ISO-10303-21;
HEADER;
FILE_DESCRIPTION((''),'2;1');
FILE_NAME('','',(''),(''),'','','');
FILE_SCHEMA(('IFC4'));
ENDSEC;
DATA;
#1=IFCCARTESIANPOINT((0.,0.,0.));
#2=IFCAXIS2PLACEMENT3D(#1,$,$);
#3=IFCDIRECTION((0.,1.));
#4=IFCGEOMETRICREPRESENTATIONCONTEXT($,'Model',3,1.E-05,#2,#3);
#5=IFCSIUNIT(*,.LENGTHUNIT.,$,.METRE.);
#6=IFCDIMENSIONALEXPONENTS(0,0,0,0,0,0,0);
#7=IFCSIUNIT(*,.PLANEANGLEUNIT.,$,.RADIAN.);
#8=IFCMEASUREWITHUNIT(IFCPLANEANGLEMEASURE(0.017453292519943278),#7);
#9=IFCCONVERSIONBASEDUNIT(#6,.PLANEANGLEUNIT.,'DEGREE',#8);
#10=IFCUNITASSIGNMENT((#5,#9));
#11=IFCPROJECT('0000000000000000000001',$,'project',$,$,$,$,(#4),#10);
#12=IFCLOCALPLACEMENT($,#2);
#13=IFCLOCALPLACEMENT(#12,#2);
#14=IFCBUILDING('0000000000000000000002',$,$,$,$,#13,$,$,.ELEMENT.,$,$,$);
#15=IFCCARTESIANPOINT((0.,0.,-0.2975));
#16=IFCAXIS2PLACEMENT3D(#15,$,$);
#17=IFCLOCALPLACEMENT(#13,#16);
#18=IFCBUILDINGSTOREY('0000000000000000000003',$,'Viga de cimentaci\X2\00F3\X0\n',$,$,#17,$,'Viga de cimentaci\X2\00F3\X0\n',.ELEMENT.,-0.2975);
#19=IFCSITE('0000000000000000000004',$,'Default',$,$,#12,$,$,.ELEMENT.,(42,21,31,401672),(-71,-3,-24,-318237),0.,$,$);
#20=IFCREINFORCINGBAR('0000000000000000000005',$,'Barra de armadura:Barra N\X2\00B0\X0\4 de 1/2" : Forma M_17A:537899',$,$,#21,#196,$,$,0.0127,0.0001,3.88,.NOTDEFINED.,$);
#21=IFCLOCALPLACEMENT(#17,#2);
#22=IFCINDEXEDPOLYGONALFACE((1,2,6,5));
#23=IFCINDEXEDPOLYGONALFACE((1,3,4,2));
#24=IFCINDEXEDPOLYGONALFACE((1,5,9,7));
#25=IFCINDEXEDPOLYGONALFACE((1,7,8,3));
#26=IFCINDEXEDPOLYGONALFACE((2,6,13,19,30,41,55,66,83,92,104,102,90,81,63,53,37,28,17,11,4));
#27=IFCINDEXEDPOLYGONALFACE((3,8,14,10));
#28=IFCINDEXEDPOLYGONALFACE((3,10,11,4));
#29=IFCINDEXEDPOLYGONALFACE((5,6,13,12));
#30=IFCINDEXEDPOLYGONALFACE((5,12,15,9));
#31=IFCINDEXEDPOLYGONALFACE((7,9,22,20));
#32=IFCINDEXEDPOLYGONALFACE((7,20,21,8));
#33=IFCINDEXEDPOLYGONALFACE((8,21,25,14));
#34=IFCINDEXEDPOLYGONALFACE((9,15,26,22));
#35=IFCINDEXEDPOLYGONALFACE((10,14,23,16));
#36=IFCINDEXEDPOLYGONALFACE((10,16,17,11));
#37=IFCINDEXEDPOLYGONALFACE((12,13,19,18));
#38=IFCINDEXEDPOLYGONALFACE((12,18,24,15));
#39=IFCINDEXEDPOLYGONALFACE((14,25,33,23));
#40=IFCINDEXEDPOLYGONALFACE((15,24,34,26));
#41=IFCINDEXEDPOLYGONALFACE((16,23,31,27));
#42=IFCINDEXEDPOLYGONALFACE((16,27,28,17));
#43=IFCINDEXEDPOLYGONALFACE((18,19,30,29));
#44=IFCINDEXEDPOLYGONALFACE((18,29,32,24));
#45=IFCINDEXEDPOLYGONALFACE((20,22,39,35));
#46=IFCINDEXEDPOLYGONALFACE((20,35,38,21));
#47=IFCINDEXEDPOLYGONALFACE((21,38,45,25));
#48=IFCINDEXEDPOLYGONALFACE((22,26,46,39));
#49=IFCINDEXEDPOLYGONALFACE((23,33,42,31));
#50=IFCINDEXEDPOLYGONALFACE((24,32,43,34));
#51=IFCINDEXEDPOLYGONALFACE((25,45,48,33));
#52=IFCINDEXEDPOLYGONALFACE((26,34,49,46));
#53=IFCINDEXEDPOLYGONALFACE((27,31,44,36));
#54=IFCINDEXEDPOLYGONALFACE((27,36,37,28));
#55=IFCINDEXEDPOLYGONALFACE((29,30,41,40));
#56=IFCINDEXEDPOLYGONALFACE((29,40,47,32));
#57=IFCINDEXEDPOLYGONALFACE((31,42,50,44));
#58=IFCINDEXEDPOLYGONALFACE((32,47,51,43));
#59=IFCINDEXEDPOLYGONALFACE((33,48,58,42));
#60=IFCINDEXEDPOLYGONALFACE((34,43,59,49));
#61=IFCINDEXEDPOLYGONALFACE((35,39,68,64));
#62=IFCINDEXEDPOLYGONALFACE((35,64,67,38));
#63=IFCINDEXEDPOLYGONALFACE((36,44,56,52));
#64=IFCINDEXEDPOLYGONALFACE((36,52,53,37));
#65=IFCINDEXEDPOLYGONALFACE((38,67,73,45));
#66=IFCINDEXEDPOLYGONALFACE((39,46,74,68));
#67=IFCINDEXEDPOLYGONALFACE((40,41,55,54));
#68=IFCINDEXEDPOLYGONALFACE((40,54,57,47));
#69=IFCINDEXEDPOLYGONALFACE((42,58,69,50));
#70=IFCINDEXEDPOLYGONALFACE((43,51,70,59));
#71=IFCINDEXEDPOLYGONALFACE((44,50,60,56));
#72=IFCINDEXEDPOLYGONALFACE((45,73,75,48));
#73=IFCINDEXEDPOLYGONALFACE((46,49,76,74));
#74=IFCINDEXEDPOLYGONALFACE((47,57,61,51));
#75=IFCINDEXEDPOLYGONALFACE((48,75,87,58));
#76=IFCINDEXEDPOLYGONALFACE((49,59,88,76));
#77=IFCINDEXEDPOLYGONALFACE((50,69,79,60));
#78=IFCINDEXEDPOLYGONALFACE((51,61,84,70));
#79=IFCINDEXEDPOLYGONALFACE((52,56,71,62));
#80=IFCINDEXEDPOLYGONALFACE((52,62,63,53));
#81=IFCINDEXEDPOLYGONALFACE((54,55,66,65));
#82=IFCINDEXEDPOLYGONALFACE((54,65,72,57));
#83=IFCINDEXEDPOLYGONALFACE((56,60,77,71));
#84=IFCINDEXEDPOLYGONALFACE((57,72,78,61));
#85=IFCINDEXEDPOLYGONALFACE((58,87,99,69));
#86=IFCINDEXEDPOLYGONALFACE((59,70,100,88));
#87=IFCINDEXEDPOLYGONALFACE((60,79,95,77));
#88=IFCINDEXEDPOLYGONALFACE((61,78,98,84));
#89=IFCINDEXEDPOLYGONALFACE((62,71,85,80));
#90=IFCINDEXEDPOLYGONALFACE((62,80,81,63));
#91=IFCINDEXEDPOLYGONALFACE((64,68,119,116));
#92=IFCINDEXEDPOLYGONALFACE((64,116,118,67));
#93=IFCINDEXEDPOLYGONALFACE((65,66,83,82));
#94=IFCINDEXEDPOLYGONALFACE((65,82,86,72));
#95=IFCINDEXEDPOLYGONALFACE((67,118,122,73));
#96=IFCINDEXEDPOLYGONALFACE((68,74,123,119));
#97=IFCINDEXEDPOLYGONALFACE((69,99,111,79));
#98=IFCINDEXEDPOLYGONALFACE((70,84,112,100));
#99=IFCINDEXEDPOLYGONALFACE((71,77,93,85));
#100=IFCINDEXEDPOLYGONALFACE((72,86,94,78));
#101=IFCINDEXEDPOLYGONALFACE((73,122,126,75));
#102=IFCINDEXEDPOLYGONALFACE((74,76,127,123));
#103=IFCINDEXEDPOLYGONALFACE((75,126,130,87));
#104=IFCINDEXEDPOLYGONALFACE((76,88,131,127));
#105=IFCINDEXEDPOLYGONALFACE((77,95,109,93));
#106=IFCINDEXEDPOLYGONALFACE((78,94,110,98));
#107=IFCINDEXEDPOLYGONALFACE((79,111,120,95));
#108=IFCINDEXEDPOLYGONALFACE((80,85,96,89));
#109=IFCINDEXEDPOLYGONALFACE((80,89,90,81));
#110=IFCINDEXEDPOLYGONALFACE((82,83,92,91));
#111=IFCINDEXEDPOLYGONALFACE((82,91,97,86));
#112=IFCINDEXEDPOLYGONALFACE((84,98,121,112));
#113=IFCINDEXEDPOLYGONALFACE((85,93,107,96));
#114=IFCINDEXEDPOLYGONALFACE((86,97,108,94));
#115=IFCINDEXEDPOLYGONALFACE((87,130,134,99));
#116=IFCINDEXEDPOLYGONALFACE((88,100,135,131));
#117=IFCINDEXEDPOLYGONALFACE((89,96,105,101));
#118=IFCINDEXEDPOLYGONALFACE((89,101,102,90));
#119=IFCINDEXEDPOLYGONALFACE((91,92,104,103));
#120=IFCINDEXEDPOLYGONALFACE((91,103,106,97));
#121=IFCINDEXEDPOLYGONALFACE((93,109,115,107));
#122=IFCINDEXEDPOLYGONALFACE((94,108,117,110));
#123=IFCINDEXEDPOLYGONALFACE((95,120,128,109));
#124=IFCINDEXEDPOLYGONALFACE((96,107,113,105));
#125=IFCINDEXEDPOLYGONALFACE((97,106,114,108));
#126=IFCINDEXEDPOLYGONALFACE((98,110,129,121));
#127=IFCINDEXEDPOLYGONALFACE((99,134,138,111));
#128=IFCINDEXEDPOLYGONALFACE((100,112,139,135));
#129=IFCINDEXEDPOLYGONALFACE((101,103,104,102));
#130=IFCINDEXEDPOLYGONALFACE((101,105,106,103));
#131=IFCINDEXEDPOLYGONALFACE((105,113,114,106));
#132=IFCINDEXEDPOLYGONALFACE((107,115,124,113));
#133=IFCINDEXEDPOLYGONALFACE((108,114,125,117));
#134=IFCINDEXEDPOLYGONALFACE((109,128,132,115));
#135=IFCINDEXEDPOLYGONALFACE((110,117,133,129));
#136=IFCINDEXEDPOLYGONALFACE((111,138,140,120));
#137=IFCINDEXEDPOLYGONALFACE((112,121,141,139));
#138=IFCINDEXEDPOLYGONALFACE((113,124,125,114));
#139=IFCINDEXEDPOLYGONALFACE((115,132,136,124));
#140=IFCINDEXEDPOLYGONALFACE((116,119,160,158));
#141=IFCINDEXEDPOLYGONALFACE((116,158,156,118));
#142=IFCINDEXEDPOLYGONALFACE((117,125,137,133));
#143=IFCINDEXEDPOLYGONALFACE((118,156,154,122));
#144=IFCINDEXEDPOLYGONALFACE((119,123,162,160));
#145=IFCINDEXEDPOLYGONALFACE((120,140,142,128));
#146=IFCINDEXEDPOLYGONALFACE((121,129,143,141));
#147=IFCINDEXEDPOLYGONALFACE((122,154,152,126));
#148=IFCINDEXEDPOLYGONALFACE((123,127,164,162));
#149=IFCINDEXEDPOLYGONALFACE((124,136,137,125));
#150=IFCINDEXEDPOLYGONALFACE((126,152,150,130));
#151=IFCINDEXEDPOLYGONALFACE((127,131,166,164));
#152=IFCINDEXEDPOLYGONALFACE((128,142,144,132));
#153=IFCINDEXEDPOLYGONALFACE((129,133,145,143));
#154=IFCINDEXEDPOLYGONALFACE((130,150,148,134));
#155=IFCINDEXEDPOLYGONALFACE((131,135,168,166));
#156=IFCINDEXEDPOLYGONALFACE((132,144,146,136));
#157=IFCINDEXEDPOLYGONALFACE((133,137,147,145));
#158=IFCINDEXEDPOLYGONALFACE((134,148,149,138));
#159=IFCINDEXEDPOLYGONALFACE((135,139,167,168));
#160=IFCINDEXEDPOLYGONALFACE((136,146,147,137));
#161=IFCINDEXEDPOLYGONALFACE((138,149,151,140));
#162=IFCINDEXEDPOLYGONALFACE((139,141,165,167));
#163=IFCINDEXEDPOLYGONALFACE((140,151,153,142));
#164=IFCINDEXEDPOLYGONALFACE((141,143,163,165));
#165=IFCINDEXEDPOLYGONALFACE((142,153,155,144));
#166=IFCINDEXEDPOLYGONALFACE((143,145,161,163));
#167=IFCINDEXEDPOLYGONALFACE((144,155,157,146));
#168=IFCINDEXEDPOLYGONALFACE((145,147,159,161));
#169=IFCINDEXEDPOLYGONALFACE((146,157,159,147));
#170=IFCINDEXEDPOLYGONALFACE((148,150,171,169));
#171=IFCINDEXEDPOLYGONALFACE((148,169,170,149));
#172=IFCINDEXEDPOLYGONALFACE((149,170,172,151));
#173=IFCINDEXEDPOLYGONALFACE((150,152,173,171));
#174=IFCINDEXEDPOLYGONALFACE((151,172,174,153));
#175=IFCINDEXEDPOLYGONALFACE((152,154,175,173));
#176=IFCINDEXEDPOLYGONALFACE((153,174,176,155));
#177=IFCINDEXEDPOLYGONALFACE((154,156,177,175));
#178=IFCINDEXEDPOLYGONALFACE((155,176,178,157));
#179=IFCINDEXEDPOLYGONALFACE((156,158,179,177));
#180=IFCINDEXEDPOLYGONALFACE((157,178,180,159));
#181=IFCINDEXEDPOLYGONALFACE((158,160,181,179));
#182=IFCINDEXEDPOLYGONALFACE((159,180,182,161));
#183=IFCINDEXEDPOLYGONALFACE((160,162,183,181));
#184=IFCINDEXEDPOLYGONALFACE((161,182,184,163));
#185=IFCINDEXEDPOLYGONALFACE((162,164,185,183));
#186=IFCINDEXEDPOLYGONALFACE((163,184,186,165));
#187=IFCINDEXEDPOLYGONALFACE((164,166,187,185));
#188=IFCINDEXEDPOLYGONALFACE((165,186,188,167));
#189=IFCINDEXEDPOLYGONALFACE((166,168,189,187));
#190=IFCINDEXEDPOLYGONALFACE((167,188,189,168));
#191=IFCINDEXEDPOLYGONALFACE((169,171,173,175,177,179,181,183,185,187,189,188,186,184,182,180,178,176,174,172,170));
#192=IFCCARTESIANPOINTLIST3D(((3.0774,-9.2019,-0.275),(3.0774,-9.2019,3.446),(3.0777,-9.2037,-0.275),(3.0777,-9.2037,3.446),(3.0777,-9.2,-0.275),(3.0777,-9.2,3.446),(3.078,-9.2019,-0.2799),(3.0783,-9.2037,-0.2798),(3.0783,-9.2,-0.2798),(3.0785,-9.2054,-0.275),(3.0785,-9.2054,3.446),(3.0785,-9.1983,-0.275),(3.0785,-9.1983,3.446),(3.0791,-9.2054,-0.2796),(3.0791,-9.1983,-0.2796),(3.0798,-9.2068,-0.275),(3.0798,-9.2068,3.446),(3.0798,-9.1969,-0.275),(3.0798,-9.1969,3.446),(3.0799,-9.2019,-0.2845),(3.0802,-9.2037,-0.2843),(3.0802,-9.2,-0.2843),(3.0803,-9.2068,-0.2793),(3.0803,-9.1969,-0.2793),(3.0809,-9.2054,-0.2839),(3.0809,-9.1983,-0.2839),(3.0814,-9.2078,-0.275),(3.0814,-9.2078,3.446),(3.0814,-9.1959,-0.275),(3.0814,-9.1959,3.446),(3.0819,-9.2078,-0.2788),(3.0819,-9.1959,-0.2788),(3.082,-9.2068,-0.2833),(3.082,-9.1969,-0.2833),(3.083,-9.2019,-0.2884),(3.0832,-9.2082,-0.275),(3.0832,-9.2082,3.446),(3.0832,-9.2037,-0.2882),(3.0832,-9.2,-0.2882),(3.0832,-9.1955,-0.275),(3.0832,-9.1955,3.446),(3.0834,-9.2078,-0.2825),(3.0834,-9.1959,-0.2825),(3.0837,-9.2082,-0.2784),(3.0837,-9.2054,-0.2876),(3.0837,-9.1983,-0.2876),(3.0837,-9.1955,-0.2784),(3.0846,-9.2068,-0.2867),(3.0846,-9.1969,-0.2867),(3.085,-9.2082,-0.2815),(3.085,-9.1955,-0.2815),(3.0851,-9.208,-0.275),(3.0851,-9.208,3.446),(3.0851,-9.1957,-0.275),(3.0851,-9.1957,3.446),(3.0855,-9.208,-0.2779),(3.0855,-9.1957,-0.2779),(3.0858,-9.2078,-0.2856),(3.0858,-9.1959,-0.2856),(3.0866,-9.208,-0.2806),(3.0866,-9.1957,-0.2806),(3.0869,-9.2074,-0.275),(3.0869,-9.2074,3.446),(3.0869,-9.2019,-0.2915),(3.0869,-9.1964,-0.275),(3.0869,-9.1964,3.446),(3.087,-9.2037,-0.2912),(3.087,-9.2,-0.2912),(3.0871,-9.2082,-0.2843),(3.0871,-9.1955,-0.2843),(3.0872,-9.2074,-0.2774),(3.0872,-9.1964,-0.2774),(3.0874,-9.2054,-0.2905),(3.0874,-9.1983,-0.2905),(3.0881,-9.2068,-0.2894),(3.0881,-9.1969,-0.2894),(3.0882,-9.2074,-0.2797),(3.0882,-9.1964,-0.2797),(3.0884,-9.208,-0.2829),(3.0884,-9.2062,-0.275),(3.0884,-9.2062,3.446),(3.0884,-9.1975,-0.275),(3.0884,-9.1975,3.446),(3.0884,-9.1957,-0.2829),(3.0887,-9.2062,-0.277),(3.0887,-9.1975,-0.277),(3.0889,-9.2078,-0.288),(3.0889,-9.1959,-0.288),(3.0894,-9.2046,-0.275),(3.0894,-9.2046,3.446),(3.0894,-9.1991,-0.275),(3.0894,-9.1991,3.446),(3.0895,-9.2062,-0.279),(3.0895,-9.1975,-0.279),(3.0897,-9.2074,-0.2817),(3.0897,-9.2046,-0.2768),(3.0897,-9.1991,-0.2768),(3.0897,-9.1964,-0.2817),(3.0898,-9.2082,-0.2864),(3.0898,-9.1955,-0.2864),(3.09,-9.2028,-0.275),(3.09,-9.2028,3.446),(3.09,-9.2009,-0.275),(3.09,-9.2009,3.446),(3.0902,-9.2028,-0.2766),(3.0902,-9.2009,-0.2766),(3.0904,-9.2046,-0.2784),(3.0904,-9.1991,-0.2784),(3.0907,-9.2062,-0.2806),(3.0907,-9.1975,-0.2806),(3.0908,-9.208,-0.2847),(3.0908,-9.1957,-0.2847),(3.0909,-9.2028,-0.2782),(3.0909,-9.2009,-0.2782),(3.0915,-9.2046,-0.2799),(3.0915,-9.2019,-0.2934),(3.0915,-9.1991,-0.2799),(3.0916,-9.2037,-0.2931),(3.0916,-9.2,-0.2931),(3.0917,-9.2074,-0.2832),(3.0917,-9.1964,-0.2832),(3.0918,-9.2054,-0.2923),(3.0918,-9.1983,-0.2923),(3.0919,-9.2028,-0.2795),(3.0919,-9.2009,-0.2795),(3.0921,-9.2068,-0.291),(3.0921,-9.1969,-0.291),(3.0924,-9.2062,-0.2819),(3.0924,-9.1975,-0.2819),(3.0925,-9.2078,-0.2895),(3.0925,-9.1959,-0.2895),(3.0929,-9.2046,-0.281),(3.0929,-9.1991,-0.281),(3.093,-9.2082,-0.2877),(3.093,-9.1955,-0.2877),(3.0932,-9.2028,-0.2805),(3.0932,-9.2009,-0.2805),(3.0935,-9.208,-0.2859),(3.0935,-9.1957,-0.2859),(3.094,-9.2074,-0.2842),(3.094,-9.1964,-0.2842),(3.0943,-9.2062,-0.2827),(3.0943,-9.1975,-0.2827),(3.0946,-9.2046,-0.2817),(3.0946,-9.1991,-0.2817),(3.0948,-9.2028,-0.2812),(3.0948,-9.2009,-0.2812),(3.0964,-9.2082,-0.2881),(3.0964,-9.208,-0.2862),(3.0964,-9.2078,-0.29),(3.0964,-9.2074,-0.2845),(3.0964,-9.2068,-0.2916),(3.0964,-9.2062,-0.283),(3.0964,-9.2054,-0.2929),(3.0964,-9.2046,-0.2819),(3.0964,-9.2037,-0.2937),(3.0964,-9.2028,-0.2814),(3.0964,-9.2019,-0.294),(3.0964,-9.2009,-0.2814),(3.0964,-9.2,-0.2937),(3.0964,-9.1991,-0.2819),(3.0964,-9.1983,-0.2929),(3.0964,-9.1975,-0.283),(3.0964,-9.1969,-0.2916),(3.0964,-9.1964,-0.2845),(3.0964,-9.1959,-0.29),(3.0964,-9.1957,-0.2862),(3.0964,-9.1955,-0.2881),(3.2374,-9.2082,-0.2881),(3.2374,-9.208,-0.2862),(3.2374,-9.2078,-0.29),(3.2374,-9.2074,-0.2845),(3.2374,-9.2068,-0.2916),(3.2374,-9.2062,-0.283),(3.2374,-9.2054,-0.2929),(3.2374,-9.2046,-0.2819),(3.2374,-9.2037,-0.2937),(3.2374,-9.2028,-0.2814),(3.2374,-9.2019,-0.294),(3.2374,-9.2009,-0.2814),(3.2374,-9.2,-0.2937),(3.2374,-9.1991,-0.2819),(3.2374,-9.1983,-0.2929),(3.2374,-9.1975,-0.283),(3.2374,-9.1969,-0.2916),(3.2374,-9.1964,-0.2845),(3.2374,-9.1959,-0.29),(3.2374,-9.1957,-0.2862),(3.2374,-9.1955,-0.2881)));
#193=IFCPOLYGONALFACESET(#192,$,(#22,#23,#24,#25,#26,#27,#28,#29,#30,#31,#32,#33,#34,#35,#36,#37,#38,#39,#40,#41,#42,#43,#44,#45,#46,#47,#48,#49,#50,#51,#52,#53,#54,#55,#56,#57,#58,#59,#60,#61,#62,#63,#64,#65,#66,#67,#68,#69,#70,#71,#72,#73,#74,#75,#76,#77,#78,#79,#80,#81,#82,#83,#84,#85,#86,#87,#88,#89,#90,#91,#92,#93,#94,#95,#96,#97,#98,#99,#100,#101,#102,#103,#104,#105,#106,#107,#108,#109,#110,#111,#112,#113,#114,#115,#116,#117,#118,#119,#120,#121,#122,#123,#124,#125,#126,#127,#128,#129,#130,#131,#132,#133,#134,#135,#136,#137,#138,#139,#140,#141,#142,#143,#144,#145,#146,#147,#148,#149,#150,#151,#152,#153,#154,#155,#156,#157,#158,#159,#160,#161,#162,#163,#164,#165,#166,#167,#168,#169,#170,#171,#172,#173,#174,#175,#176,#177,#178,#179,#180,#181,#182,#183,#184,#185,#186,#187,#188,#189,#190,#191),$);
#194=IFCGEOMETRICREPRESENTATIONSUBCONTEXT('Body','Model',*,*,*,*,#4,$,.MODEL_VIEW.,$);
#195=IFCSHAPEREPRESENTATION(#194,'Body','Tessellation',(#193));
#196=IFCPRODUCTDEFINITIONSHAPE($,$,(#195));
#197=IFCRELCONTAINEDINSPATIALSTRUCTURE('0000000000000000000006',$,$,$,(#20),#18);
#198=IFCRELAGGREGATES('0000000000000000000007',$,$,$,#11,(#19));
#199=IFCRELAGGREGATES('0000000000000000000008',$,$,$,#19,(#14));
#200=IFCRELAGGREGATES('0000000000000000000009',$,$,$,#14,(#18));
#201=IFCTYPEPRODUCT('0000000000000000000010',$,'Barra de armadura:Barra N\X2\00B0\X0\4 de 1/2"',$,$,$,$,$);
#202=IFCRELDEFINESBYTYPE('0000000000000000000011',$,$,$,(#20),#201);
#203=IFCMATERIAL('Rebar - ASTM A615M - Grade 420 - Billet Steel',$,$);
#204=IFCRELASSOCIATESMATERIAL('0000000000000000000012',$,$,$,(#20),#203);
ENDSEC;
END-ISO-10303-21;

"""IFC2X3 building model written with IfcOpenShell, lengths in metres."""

from ifc_helpers import new_model, entity, si_unit, converted_unit, direction, frame, origin, place, context, subcontext, project, spatial, material, type_object, element, save


model = new_model("IFC2X3")

# Units and contexts
model_context = context("Model", 3, precision=1e-05, world=origin(), true_north=direction((0.0, 1.0)))
body_context = subcontext(model_context, "Body", "Model", "MODEL_VIEW")
ifc_project = project(units=[si_unit("LENGTHUNIT", "METRE"), converted_unit("PLANEANGLEUNIT", "DEGREE", entity("IfcPlaneAngleMeasure", 0.017453292519943278), si_unit("PLANEANGLEUNIT", "RADIAN"), dimensions=[0, 0, 0, 0, 0, 0, 0])], contexts=[model_context])

# Site, building, storey
site_placement = place(None, origin())
site = spatial("IfcSite", under=ifc_project, at=site_placement, Name="Default", CompositionType="ELEMENT", RefLatitude=(42, 21, 31, 401672), RefLongitude=(-71, -3, -24, -318237), RefElevation=0.0)
building_placement = place(site_placement, origin())
building = spatial("IfcBuilding", under=site, at=building_placement, CompositionType="ELEMENT")
storey_placement = place(building_placement, frame((0.0, 0.0, -0.2975)))
storey = spatial("IfcBuildingStorey", under=building, at=storey_placement, Name="Viga de cimentación", LongName="Viga de cimentación", CompositionType="ELEMENT", Elevation=-0.2975)

# Reinforcing bar
ifc_material = material(Name="Rebar - ASTM A615M - Grade 420 - Billet Steel")
type_product_1 = type_object("IfcTypeProduct", Name="Barra de armadura:Barra N°4 de 1/2\"")
reinforcing_bar_1_placement = place(storey_placement, origin())
element("IfcReinforcingBar", 1, at=reinforcing_bar_1_placement, inside=storey, type_object=type_product_1, material=ifc_material, Name="Barra de armadura:Barra N°4 de 1/2\" : Forma M_17A:537899", BarLength=3.88, BarRole="NOTDEFINED", CrossSectionArea=0.0001, NominalDiameter=0.0127, context=body_context, shape_type="AdvancedSweptSolid", body=[
    entity("IfcSweptDiskSolid", entity("IfcCompositeCurve", [entity("IfcCompositeCurveSegment", "CONTINUOUS", True, entity("IfcPolyline", [entity("IfcCartesianPoint", [3.0837, -9.2019, 3.446]), entity("IfcCartesianPoint", [3.0837, -9.2019, -0.275])])), entity("IfcCompositeCurveSegment", "CONTINUOUS", True, entity("IfcTrimmedCurve", entity("IfcCircle", entity("IfcAxis2Placement3D", entity("IfcCartesianPoint", [3.0964, -9.2019, -0.275]), entity("IfcDirection", [0.0, -1.0, 0.0]), entity("IfcDirection", [0.0, 0.0, -1.0])), 0.0127), [entity("IfcParameterValue", 270.0)], [entity("IfcParameterValue", 360.0)], True, "PARAMETER")), entity("IfcCompositeCurveSegment", "CONTINUOUS", True, entity("IfcPolyline", [entity("IfcCartesianPoint", [3.0964, -9.2019, -0.2877]), entity("IfcCartesianPoint", [3.2374, -9.2019, -0.2877])]))], False), 0.0063, None, 0.0, 92.0),
])

save(model, "model.ifc")
